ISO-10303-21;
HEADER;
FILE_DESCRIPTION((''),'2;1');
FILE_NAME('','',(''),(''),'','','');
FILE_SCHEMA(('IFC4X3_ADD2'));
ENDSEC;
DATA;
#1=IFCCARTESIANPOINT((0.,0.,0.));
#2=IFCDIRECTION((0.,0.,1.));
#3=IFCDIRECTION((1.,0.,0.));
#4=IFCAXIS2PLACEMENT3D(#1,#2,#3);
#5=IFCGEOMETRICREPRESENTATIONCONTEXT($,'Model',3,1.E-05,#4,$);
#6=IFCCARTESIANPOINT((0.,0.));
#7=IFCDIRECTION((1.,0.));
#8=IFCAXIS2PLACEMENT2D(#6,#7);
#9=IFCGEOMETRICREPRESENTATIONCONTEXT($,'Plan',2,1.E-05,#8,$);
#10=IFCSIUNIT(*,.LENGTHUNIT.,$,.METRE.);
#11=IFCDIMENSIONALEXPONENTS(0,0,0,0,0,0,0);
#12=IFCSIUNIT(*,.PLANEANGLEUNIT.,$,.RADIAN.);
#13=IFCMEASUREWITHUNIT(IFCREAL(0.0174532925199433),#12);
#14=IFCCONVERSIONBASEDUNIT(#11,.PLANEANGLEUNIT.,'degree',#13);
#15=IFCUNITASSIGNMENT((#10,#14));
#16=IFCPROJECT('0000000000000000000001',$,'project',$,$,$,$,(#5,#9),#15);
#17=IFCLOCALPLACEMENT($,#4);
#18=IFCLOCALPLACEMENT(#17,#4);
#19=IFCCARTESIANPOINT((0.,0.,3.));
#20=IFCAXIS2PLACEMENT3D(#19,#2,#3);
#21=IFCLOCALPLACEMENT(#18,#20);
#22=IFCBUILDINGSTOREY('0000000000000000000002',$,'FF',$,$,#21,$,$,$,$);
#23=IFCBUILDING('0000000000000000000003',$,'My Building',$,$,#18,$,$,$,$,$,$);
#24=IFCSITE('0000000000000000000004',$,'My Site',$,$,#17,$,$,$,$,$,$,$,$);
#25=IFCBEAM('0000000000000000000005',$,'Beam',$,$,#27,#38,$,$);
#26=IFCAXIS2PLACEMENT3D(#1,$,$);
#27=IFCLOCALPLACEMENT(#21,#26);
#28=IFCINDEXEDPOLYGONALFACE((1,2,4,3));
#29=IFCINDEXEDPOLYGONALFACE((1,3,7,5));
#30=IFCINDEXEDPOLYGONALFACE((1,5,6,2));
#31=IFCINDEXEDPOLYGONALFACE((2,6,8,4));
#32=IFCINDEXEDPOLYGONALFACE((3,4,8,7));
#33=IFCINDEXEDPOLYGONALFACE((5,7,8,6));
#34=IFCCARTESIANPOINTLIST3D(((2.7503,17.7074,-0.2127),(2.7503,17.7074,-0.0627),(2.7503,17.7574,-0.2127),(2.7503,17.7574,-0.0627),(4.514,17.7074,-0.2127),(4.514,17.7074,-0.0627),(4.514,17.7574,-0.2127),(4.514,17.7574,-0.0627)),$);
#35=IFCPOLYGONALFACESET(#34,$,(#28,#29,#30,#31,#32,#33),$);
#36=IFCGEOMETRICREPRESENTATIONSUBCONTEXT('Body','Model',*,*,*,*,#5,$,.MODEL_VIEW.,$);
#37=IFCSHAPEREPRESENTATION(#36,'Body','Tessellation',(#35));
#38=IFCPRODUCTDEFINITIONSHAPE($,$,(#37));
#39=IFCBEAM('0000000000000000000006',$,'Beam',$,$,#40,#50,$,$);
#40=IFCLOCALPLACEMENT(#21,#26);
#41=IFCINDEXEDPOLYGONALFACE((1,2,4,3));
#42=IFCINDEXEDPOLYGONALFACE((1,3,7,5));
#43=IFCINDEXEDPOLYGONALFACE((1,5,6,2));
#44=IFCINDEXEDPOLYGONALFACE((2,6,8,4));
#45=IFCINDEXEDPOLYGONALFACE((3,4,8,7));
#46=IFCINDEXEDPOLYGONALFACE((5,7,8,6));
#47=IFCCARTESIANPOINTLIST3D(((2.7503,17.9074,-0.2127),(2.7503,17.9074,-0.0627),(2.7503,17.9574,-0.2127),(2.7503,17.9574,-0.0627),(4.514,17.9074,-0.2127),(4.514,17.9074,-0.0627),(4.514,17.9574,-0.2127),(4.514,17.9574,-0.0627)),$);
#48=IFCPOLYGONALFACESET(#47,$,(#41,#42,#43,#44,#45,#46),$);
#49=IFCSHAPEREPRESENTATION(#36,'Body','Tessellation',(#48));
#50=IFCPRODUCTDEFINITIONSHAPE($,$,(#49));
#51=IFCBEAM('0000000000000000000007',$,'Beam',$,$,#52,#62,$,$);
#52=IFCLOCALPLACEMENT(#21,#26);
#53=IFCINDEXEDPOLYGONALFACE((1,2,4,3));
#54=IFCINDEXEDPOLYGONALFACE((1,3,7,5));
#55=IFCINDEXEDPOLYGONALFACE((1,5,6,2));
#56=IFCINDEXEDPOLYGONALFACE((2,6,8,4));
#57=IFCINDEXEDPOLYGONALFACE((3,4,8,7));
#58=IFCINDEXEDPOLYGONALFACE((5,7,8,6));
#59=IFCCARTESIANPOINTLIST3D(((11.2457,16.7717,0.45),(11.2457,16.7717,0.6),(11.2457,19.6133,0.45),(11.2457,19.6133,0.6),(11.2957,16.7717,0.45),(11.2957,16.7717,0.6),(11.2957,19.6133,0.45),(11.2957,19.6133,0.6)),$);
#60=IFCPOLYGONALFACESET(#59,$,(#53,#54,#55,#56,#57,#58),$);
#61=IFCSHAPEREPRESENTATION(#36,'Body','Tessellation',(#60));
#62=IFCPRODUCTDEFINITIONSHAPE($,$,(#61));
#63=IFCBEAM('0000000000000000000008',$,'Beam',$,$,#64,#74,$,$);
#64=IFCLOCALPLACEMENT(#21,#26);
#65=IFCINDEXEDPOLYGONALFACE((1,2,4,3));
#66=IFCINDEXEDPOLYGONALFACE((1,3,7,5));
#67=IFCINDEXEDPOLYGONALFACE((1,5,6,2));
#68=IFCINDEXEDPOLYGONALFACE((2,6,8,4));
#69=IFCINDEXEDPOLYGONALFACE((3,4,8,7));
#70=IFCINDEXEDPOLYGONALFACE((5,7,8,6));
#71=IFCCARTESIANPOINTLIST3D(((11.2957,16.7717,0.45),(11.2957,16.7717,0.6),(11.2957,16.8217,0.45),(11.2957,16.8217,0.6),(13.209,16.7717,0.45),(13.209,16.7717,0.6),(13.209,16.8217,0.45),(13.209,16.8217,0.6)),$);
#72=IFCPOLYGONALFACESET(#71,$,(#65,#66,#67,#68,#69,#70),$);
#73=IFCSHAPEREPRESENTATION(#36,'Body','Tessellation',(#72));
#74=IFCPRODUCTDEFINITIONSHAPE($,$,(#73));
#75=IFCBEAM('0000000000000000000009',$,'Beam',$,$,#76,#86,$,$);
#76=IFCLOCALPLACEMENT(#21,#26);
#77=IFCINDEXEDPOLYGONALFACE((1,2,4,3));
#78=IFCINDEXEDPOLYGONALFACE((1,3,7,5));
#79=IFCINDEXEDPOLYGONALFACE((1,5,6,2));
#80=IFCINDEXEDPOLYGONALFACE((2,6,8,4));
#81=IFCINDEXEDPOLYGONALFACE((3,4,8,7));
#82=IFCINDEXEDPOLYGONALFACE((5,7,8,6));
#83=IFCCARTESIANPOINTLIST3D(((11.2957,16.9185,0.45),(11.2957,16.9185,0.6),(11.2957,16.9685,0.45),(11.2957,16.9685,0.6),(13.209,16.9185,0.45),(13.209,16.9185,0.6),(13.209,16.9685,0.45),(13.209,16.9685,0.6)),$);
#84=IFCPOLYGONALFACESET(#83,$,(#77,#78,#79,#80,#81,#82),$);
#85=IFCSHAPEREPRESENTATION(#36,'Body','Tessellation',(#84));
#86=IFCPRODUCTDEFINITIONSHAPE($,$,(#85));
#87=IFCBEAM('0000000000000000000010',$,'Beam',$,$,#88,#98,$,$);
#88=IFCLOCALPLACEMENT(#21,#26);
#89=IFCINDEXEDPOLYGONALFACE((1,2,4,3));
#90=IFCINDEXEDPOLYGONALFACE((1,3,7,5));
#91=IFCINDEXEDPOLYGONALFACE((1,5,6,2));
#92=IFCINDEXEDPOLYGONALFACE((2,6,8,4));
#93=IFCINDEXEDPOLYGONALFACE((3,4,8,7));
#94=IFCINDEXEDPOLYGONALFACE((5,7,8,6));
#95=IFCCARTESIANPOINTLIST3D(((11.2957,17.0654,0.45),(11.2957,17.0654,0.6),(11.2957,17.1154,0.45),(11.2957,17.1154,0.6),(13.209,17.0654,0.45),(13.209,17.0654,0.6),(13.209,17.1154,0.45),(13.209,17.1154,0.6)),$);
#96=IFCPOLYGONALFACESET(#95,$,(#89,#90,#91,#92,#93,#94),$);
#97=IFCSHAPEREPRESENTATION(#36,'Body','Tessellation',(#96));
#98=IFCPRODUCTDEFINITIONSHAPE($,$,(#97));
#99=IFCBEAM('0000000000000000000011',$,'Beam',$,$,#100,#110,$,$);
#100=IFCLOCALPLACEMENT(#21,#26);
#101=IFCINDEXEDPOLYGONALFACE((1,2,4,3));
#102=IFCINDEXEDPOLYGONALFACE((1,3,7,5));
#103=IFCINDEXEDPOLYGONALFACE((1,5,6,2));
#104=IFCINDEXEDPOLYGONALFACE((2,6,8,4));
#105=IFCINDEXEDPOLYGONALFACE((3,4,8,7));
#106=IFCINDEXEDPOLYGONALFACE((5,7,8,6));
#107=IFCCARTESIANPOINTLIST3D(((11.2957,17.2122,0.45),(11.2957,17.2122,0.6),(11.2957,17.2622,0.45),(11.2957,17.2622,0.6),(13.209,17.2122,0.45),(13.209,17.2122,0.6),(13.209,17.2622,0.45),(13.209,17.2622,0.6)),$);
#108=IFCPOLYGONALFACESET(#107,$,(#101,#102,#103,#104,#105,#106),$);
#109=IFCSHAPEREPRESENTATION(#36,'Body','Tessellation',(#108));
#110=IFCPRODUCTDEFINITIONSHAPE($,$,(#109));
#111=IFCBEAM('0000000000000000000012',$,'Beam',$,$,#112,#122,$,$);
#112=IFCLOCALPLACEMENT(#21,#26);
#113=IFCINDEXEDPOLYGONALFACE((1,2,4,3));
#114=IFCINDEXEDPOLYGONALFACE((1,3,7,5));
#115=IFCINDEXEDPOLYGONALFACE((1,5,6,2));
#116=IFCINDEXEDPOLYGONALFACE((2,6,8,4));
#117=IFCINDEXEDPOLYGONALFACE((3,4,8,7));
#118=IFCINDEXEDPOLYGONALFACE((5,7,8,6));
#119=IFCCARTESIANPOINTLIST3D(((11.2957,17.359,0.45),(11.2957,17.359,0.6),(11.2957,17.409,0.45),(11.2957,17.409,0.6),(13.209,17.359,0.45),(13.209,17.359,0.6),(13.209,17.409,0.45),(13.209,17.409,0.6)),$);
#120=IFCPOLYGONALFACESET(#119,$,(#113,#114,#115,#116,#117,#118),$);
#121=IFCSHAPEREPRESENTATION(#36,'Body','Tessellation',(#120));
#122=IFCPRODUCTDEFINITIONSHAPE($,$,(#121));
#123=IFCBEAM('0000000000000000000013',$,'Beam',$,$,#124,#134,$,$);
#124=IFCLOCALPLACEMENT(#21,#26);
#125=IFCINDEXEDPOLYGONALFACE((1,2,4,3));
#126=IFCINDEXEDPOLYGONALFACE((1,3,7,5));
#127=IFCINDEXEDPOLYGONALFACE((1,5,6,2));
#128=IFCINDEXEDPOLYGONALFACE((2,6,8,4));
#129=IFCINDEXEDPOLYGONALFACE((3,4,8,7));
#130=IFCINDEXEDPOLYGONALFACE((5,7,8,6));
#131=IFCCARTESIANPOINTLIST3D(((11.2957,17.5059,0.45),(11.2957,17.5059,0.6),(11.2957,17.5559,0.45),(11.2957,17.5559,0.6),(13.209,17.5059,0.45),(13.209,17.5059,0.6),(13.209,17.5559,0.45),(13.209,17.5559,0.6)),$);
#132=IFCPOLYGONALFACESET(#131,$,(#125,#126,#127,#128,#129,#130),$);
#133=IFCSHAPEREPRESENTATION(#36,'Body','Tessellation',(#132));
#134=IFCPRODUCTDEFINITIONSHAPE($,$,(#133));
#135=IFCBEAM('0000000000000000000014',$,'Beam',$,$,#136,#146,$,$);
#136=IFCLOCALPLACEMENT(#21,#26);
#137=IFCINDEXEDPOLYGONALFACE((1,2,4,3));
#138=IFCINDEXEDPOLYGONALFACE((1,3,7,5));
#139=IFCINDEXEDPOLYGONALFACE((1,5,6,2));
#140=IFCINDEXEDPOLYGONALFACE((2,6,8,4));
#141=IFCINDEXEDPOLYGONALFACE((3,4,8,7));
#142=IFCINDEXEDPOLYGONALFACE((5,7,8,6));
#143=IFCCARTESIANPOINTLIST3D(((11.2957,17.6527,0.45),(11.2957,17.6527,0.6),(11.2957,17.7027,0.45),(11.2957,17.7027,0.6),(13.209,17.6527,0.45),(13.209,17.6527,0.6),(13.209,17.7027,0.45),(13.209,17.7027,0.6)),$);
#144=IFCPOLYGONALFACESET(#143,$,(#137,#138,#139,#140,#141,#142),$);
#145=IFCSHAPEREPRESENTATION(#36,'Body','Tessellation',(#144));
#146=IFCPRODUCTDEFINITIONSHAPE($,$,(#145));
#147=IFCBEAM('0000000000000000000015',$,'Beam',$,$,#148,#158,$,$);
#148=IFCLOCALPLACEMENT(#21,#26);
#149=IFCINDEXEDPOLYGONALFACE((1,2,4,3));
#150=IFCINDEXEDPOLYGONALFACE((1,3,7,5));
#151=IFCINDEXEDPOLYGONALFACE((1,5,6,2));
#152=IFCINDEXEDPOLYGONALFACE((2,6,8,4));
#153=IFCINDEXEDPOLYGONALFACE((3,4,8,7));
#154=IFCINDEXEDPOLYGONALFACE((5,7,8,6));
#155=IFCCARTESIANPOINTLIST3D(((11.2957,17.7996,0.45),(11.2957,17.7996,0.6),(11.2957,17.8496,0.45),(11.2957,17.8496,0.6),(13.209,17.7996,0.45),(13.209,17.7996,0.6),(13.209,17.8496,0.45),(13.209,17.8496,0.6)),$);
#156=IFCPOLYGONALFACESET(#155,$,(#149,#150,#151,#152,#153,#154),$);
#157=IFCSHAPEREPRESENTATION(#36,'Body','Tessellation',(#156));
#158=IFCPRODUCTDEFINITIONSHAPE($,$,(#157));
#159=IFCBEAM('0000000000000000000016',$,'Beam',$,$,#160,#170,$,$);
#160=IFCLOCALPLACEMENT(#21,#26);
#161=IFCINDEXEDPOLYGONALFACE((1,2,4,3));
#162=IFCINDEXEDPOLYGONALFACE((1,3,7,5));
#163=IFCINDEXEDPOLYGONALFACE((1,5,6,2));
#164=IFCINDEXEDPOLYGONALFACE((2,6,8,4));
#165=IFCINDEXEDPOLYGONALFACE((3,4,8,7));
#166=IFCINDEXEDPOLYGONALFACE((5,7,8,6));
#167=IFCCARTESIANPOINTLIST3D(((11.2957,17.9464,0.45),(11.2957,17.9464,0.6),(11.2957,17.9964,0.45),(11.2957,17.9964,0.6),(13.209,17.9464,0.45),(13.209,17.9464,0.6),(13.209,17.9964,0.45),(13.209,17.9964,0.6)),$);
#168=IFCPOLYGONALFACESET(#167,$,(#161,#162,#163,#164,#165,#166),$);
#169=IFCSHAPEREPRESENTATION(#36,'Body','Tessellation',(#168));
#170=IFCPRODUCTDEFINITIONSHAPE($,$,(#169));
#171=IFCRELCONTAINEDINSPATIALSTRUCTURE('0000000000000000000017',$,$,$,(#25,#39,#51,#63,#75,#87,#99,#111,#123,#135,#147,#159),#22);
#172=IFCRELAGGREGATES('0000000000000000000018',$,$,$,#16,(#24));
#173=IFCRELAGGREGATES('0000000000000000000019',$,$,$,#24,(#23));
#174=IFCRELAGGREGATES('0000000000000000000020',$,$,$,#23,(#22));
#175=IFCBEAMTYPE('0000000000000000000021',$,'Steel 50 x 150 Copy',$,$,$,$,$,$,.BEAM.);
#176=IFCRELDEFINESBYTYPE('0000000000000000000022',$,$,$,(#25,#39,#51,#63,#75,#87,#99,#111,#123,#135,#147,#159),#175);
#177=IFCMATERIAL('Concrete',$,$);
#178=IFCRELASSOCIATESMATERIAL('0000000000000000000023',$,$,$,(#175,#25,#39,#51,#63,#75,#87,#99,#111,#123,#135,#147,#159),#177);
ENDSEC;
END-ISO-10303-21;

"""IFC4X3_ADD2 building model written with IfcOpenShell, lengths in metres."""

from ifc_helpers import new_model, entity, si_unit, converted_unit, frame, origin_with_axes, origin_2d_with_axis, place, context, subcontext, project, spatial, rectangle, extrude, material, material_profile, profile_set, profile_usage, type_object, element, save


model = new_model("IFC4X3_ADD2")

# Units and contexts
model_context = context("Model", 3, precision=1e-05, world=origin_with_axes())
plan_context = context("Plan", 2, precision=1e-05, world=origin_2d_with_axis())
body_context = subcontext(model_context, "Body", "Model", "MODEL_VIEW")
ifc_project = project(units=[si_unit("LENGTHUNIT", "METRE"), converted_unit("PLANEANGLEUNIT", "degree", entity("IfcReal", 0.0174532925199433), si_unit("PLANEANGLEUNIT", "RADIAN"), dimensions=[0, 0, 0, 0, 0, 0, 0])], contexts=[model_context, plan_context])

# Site, building, storey
site_placement = place(None, origin_with_axes())
site = spatial("IfcSite", under=ifc_project, at=site_placement, Name="My Site")
building_placement = place(site_placement, origin_with_axes())
building = spatial("IfcBuilding", under=site, at=building_placement, Name="My Building")
storey_placement = place(building_placement, frame((0.0, 0.0, 3.0), z_axis=(0.0, 0.0, 1.0), x_axis=(1.0, 0.0, 0.0)))
storey = spatial("IfcBuildingStorey", under=building, at=storey_placement, Name="FF")

# Beams
ifc_material = material(Name="Concrete")
ifc_material_profile_1 = material_profile(ifc_material, rectangle(XDim=0.05, YDim=0.15))
ifc_profile_set_1 = profile_set([ifc_material_profile_1])
beam_type_1 = type_object("IfcBeamType", Name="Steel 50 x 150 Copy", PredefinedType="BEAM", material=ifc_profile_set_1)
ifc_profile_usage_1 = profile_usage(ifc_profile_set_1)
beam_1_placement = place(storey_placement, frame((2.7503, 17.7324, -0.1377), z_axis=(1.0, 0.0, 0.0), x_axis=(0.0, 1.0, 0.0)))
element("IfcBeam", 1, at=beam_1_placement, inside=storey, type_object=beam_type_1, material=ifc_profile_usage_1, Name="Beam", context=body_context, shape_type="SweptSolid", body=[
    extrude(rectangle(XDim=0.05, YDim=0.15), origin_with_axes(), (0.0, 0.0, 1.0), 1.7638),
])
ifc_profile_usage_2 = profile_usage(ifc_profile_set_1)
beam_2_placement = place(storey_placement, frame((2.7503, 17.9324, -0.1377), z_axis=(1.0, 0.0, 0.0), x_axis=(0.0, 1.0, 0.0)))
element("IfcBeam", 2, at=beam_2_placement, inside=storey, type_object=beam_type_1, material=ifc_profile_usage_2, Name="Beam", context=body_context, shape_type="SweptSolid", body=[
    extrude(rectangle(XDim=0.05, YDim=0.15), origin_with_axes(), (0.0, 0.0, 1.0), 1.7638),
])
ifc_profile_usage_3 = profile_usage(ifc_profile_set_1)
beam_3_placement = place(storey_placement, frame((11.2707, 16.7717, 0.525), z_axis=(0.0, 1.0, 0.0), x_axis=(-1.0, 0.0, 0.0)))
element("IfcBeam", 3, at=beam_3_placement, inside=storey, type_object=beam_type_1, material=ifc_profile_usage_3, Name="Beam", context=body_context, shape_type="SweptSolid", body=[
    extrude(rectangle(XDim=0.05, YDim=0.15), origin_with_axes(), (0.0, 0.0, 1.0), 2.8416),
])
ifc_profile_usage_4 = profile_usage(ifc_profile_set_1)
beam_4_placement = place(storey_placement, frame((11.2957, 16.7967, 0.525), z_axis=(1.0, 0.0, 0.0), x_axis=(0.0, 1.0, 0.0)))
element("IfcBeam", 4, at=beam_4_placement, inside=storey, type_object=beam_type_1, material=ifc_profile_usage_4, Name="Beam", context=body_context, shape_type="SweptSolid", body=[
    extrude(rectangle(XDim=0.05, YDim=0.15), origin_with_axes(), (0.0, 0.0, 1.0), 1.9133),
])
ifc_profile_usage_5 = profile_usage(ifc_profile_set_1)
beam_5_placement = place(storey_placement, frame((11.2957, 16.9435, 0.525), z_axis=(1.0, 0.0, 0.0), x_axis=(0.0, 1.0, 0.0)))
element("IfcBeam", 5, at=beam_5_placement, inside=storey, type_object=beam_type_1, material=ifc_profile_usage_5, Name="Beam", context=body_context, shape_type="SweptSolid", body=[
    extrude(rectangle(XDim=0.05, YDim=0.15), origin_with_axes(), (0.0, 0.0, 1.0), 1.9133),
])
ifc_profile_usage_6 = profile_usage(ifc_profile_set_1)
beam_6_placement = place(storey_placement, frame((11.2957, 17.0904, 0.525), z_axis=(1.0, 0.0, 0.0), x_axis=(0.0, 1.0, 0.0)))
element("IfcBeam", 6, at=beam_6_placement, inside=storey, type_object=beam_type_1, material=ifc_profile_usage_6, Name="Beam", context=body_context, shape_type="SweptSolid", body=[
    extrude(rectangle(XDim=0.05, YDim=0.15), origin_with_axes(), (0.0, 0.0, 1.0), 1.9133),
])
ifc_profile_usage_7 = profile_usage(ifc_profile_set_1)
beam_7_placement = place(storey_placement, frame((11.2957, 17.2372, 0.525), z_axis=(1.0, 0.0, 0.0), x_axis=(0.0, 1.0, 0.0)))
element("IfcBeam", 7, at=beam_7_placement, inside=storey, type_object=beam_type_1, material=ifc_profile_usage_7, Name="Beam", context=body_context, shape_type="SweptSolid", body=[
    extrude(rectangle(XDim=0.05, YDim=0.15), origin_with_axes(), (0.0, 0.0, 1.0), 1.9133),
])
ifc_profile_usage_8 = profile_usage(ifc_profile_set_1)
beam_8_placement = place(storey_placement, frame((11.2957, 17.384, 0.525), z_axis=(1.0, 0.0, 0.0), x_axis=(0.0, 1.0, 0.0)))
element("IfcBeam", 8, at=beam_8_placement, inside=storey, type_object=beam_type_1, material=ifc_profile_usage_8, Name="Beam", context=body_context, shape_type="SweptSolid", body=[
    extrude(rectangle(XDim=0.05, YDim=0.15), origin_with_axes(), (0.0, 0.0, 1.0), 1.9133),
])
ifc_profile_usage_9 = profile_usage(ifc_profile_set_1)
beam_9_placement = place(storey_placement, frame((11.2957, 17.5309, 0.525), z_axis=(1.0, 0.0, 0.0), x_axis=(0.0, 1.0, 0.0)))
element("IfcBeam", 9, at=beam_9_placement, inside=storey, type_object=beam_type_1, material=ifc_profile_usage_9, Name="Beam", context=body_context, shape_type="SweptSolid", body=[
    extrude(rectangle(XDim=0.05, YDim=0.15), origin_with_axes(), (0.0, 0.0, 1.0), 1.9133),
])
ifc_profile_usage_10 = profile_usage(ifc_profile_set_1)
beam_10_placement = place(storey_placement, frame((11.2957, 17.6777, 0.525), z_axis=(1.0, 0.0, 0.0), x_axis=(0.0, 1.0, 0.0)))
element("IfcBeam", 10, at=beam_10_placement, inside=storey, type_object=beam_type_1, material=ifc_profile_usage_10, Name="Beam", context=body_context, shape_type="SweptSolid", body=[
    extrude(rectangle(XDim=0.05, YDim=0.15), origin_with_axes(), (0.0, 0.0, 1.0), 1.9133),
])
ifc_profile_usage_11 = profile_usage(ifc_profile_set_1)
beam_11_placement = place(storey_placement, frame((11.2957, 17.8246, 0.525), z_axis=(1.0, 0.0, 0.0), x_axis=(0.0, 1.0, 0.0)))
element("IfcBeam", 11, at=beam_11_placement, inside=storey, type_object=beam_type_1, material=ifc_profile_usage_11, Name="Beam", context=body_context, shape_type="SweptSolid", body=[
    extrude(rectangle(XDim=0.05, YDim=0.15), origin_with_axes(), (0.0, 0.0, 1.0), 1.9133),
])
ifc_profile_usage_12 = profile_usage(ifc_profile_set_1)
beam_12_placement = place(storey_placement, frame((11.2957, 17.9714, 0.525), z_axis=(1.0, 0.0, 0.0), x_axis=(0.0, 1.0, 0.0)))
element("IfcBeam", 12, at=beam_12_placement, inside=storey, type_object=beam_type_1, material=ifc_profile_usage_12, Name="Beam", context=body_context, shape_type="SweptSolid", body=[
    extrude(rectangle(XDim=0.05, YDim=0.15), origin_with_axes(), (0.0, 0.0, 1.0), 1.9133),
])

save(model, "model.ifc")
